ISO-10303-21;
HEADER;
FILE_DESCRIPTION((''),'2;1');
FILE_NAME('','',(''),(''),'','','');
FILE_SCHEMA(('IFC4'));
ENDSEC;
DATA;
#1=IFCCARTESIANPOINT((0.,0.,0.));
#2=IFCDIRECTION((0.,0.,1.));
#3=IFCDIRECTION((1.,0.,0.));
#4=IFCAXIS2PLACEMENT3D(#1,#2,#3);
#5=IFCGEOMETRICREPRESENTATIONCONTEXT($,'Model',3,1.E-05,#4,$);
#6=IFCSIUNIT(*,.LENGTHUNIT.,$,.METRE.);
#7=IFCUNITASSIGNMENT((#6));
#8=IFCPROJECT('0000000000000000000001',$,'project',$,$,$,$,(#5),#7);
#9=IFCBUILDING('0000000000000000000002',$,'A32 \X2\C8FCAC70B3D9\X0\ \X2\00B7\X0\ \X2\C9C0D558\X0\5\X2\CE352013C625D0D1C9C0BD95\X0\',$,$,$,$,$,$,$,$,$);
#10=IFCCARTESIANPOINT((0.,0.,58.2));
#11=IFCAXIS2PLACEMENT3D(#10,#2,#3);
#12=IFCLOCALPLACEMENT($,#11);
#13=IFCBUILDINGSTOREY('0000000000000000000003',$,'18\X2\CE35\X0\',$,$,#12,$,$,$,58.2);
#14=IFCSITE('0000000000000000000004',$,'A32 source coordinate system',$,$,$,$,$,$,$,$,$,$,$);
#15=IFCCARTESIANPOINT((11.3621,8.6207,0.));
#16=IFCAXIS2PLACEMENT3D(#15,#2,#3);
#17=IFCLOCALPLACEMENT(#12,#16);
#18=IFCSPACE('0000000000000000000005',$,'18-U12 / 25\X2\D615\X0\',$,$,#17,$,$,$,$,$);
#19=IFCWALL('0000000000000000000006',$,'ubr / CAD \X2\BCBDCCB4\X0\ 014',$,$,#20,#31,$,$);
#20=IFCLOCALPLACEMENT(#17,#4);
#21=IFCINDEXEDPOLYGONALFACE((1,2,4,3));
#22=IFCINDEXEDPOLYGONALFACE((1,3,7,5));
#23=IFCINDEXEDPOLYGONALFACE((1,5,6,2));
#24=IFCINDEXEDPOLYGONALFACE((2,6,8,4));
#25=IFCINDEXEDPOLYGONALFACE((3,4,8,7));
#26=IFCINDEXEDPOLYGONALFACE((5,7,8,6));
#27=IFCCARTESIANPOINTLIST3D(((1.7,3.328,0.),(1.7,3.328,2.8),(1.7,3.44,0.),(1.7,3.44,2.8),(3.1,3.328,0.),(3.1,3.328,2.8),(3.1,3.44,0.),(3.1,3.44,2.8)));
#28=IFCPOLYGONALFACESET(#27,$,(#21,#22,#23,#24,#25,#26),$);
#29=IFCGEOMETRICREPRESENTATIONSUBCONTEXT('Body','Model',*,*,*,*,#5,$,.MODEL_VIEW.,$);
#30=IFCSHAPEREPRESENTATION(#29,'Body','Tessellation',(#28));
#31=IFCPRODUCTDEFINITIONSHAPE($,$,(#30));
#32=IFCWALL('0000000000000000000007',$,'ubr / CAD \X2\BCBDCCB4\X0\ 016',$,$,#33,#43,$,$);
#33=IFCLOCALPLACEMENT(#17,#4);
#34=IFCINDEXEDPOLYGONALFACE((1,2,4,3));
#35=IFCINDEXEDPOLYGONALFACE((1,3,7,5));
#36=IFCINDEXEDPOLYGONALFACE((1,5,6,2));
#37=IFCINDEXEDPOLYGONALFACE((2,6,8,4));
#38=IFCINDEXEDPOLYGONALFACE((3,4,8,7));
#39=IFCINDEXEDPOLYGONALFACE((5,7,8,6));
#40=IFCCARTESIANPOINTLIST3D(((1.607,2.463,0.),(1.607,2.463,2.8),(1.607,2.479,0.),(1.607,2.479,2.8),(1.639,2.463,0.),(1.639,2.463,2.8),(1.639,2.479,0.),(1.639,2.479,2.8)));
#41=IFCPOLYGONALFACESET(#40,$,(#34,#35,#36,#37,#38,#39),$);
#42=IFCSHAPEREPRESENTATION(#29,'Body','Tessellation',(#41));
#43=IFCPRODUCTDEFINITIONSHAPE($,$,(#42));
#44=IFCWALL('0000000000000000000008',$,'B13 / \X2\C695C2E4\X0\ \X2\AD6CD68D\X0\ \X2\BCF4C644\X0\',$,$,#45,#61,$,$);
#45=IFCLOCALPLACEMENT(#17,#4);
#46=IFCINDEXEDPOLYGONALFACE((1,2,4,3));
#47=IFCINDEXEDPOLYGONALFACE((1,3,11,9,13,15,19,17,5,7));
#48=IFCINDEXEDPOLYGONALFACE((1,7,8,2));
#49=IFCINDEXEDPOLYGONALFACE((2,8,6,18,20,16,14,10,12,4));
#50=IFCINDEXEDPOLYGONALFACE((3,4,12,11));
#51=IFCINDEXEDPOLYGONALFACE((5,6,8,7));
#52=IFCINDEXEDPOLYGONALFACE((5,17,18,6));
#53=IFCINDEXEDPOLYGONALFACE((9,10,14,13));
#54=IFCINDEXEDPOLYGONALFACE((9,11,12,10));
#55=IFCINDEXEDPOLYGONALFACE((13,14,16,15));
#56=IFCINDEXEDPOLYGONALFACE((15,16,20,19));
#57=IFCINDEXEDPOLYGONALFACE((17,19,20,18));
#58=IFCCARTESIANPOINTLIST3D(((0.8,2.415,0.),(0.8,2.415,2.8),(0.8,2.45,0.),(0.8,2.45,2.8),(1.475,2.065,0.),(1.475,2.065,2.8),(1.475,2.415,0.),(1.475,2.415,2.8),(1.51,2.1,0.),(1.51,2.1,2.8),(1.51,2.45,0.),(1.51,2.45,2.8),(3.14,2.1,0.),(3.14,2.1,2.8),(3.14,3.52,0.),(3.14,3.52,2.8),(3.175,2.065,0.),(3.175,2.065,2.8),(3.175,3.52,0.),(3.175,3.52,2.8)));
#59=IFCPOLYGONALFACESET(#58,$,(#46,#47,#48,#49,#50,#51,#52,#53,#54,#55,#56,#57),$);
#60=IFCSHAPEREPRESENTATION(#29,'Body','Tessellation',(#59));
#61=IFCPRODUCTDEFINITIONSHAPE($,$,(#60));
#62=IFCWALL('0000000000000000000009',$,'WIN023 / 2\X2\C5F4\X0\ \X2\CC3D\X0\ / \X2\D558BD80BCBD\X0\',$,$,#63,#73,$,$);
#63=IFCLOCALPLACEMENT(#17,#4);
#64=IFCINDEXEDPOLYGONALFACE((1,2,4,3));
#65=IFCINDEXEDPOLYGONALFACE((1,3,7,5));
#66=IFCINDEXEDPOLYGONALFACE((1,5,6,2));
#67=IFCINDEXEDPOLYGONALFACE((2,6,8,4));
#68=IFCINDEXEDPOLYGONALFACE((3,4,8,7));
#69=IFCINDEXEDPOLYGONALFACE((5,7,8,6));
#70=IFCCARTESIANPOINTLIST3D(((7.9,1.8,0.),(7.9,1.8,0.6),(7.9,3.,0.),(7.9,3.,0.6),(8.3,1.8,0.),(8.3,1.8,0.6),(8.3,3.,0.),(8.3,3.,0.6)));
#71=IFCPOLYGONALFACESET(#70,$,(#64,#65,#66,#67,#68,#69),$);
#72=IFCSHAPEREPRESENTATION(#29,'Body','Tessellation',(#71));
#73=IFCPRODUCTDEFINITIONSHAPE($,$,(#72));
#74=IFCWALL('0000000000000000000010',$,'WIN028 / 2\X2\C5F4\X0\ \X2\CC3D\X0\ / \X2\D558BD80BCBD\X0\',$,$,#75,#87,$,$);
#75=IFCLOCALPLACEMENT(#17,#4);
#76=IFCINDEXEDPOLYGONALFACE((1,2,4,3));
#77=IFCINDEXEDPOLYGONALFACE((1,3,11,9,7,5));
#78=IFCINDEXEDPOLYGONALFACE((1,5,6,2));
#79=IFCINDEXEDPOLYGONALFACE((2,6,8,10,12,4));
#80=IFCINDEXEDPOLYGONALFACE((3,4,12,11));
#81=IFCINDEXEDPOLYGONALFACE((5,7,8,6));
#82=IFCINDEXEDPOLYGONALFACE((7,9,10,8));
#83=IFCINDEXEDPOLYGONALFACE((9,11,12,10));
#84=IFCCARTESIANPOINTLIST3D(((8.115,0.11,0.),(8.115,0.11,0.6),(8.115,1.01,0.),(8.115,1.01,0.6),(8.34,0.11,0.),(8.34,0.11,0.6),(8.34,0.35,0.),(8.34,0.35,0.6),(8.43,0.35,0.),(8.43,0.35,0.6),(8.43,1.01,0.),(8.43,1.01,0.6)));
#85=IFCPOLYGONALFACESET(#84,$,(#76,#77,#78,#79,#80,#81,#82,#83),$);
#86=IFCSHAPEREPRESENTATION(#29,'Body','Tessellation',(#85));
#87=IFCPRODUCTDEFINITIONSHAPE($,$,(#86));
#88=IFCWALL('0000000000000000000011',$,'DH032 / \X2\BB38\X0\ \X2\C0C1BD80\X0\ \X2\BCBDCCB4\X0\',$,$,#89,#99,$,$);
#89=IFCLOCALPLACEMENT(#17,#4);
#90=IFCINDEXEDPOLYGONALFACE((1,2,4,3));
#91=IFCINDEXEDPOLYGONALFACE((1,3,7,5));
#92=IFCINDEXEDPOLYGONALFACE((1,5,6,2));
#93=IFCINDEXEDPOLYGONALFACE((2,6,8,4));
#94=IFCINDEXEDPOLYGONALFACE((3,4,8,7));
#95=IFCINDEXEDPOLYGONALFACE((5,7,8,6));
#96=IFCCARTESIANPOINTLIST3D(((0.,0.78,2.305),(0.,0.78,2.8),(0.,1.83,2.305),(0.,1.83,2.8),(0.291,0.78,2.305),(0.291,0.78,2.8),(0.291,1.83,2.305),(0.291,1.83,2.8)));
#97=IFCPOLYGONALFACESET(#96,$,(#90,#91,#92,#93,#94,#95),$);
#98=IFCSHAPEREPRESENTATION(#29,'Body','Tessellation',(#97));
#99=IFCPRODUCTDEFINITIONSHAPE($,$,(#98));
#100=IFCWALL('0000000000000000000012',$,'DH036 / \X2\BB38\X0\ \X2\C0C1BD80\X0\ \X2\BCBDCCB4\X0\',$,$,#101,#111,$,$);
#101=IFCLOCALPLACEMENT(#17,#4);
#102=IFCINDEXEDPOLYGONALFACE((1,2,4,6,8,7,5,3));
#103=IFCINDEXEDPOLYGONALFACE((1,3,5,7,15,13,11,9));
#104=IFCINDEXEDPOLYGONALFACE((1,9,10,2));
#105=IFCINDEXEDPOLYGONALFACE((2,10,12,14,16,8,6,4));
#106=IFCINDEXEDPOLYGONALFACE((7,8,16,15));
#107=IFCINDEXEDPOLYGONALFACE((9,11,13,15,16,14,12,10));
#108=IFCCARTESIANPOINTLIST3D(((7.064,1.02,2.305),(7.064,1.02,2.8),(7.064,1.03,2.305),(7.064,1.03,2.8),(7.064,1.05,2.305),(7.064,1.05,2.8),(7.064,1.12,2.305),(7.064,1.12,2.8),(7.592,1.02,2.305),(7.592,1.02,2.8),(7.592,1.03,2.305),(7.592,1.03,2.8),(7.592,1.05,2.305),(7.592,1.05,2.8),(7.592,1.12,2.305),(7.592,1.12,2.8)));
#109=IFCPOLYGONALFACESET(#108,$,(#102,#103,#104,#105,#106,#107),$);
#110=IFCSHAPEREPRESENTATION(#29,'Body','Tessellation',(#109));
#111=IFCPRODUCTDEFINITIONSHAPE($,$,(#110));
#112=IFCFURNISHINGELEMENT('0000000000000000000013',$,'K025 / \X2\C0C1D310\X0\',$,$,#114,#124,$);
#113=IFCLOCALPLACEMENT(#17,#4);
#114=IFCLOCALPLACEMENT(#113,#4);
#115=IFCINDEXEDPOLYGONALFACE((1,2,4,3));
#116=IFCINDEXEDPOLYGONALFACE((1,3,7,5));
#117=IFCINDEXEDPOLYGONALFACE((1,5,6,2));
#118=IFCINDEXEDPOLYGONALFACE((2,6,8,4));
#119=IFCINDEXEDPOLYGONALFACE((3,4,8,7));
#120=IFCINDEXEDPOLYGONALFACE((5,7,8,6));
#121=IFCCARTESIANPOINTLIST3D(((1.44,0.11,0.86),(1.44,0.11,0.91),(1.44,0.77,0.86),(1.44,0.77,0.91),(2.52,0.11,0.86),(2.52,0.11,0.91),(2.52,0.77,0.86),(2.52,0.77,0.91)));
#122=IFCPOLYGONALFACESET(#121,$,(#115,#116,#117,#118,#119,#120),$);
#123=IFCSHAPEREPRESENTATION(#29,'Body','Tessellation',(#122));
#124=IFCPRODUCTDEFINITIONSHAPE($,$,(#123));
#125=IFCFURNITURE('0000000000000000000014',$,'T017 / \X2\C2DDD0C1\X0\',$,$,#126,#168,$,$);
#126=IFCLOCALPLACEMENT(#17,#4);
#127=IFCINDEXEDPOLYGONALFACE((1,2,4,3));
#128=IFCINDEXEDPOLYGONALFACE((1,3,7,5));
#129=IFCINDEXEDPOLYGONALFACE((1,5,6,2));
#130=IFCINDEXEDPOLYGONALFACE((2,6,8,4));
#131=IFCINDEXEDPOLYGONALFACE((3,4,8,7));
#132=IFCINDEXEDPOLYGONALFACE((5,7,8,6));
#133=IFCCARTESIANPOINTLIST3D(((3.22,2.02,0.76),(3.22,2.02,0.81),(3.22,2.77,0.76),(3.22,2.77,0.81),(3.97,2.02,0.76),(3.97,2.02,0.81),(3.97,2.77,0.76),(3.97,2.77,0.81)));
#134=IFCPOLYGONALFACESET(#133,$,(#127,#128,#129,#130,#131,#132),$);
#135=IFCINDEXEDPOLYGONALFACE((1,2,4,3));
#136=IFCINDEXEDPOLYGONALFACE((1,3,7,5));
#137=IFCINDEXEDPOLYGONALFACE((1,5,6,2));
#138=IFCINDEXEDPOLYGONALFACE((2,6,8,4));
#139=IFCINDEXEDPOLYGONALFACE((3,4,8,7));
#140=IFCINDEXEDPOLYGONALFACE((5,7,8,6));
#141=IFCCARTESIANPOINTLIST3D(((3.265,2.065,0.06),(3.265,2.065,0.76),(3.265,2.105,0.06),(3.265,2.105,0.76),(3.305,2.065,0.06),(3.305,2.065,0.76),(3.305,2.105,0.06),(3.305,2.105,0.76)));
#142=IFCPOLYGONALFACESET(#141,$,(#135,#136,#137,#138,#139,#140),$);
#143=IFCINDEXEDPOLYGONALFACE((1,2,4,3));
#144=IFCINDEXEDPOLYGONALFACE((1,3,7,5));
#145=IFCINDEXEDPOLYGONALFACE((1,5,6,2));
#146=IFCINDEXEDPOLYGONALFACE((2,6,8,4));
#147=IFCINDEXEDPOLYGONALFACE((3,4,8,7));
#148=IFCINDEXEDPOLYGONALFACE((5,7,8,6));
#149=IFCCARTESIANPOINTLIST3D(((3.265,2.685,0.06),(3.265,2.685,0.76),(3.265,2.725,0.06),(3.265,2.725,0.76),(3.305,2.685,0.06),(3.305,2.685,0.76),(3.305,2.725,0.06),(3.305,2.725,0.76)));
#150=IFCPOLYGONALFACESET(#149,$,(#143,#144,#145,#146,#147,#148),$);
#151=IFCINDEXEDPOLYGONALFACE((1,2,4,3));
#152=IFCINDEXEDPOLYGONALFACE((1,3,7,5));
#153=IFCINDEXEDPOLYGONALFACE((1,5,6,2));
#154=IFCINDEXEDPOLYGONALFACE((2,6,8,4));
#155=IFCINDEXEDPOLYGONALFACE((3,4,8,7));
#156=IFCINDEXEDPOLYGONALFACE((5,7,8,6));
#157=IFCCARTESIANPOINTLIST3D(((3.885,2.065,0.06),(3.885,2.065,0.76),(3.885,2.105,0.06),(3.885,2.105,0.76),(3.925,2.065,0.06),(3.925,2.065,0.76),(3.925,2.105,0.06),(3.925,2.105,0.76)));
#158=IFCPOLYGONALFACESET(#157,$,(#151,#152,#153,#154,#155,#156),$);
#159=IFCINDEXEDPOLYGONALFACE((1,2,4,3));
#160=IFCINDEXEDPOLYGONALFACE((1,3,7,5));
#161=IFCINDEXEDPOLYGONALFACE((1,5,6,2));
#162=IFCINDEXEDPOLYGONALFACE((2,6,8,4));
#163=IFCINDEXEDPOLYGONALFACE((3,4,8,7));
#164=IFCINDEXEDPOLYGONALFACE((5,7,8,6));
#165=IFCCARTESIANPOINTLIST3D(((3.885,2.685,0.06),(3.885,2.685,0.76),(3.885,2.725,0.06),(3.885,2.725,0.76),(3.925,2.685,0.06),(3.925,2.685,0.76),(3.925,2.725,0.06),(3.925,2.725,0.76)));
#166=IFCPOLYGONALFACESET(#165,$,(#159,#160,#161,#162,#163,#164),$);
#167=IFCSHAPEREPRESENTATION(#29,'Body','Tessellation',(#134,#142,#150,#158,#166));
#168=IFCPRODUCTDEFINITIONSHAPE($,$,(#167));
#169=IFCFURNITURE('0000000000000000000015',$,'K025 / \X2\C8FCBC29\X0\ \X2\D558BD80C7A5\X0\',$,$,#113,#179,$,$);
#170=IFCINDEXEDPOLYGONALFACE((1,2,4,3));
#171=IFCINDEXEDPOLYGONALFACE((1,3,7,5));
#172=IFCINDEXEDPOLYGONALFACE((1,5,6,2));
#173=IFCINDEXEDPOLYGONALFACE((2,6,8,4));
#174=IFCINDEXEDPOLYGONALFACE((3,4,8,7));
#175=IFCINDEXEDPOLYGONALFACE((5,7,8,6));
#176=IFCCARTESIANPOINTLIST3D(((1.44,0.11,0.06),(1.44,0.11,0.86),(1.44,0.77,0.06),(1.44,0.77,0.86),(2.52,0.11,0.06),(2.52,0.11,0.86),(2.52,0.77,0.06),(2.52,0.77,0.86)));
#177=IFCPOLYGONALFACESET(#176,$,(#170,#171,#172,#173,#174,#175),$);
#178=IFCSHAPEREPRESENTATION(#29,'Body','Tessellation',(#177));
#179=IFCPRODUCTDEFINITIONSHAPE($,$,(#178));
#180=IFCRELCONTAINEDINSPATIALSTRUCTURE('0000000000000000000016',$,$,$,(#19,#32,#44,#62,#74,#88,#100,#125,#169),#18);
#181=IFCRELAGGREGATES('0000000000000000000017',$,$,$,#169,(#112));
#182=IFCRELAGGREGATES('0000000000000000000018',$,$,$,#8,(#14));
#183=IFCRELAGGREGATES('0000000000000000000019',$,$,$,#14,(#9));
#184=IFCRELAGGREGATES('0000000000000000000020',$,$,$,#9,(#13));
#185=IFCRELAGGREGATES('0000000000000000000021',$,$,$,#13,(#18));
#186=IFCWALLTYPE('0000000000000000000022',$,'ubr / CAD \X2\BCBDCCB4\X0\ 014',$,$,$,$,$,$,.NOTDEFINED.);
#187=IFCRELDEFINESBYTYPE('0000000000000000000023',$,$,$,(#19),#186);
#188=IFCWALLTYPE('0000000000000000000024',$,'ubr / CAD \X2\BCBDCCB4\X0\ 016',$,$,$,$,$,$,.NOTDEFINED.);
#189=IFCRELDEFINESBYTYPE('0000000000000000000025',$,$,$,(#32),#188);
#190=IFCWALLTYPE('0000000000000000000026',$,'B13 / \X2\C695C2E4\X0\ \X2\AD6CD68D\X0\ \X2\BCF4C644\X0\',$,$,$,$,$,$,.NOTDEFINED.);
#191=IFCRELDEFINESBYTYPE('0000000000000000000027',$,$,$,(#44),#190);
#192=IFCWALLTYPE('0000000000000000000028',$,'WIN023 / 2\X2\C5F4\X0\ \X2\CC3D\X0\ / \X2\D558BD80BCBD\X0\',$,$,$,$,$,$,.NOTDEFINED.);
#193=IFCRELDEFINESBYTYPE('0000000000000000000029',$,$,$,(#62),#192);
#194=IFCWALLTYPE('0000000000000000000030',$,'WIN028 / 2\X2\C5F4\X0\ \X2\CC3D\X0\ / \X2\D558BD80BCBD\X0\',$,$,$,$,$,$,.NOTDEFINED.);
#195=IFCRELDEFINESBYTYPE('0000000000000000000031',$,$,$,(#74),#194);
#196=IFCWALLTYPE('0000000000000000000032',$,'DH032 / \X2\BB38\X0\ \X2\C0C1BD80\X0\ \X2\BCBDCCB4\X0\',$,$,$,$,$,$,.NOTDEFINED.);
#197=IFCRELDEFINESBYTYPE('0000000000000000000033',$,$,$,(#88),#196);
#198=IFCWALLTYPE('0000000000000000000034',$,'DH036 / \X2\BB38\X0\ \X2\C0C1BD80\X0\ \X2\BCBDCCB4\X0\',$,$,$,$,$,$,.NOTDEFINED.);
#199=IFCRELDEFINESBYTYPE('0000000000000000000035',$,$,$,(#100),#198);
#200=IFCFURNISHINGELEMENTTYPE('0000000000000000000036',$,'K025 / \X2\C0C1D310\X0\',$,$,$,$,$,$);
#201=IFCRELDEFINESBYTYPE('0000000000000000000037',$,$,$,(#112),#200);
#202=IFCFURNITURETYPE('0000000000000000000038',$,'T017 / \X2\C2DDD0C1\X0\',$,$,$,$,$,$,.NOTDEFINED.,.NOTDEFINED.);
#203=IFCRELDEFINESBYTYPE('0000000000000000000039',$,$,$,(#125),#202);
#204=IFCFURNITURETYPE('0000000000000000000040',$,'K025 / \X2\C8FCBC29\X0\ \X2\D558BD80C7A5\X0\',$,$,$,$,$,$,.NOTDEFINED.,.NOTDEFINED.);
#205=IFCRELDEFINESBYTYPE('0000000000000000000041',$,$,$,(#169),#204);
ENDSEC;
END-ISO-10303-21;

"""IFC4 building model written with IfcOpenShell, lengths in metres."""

from ifc_helpers import new_model, si_unit, frame, origin, origin_with_axes, place, context, subcontext, project, spatial, polyline, outline, extrude, source, transform, mapped, type_object, type_shapes, element, aggregate, save


model = new_model("IFC4")

# Units and contexts
model_context = context("Model", 3, precision=1e-05, world=origin_with_axes())
body_context = subcontext(model_context, "Body", "Model", "MODEL_VIEW")
ifc_project = project(units=[si_unit("LENGTHUNIT", "METRE")], contexts=[model_context])

# Site, building, storey, space
site = spatial("IfcSite", under=ifc_project, Name="A32 source coordinate system")
building = spatial("IfcBuilding", under=site, Name="A32 주거동 · 지하5층–옥탑지붕")
storey_placement = place(None, frame((0.0, 0.0, 58.2), z_axis=(0.0, 0.0, 1.0), x_axis=(1.0, 0.0, 0.0)))
storey = spatial("IfcBuildingStorey", under=building, at=storey_placement, Name="18층", Elevation=58.2)
space_1_placement = place(storey_placement, frame((11.3621, 8.6207, 0.0), z_axis=(0.0, 0.0, 1.0), x_axis=(1.0, 0.0, 0.0)))
space_1 = spatial("IfcSpace", under=storey, at=space_1_placement, Name="18-U12 / 25형")

# Walls
wall_type_1 = type_object("IfcWallType", Name="ubr / CAD 벽체 014", PredefinedType="NOTDEFINED")
shared_shape_1 = source(origin(), body_context, "Body", "SweptSolid", [
    extrude(outline(polyline([(3.1, 3.44), (3.1, 3.328), (1.7, 3.328), (1.7, 3.44), (3.1, 3.44)])), origin(), (0.0, 0.0, 1.0), 2.8),
])
type_shapes(wall_type_1, [shared_shape_1])
wall_1_placement = place(space_1_placement, origin_with_axes())
element("IfcWall", 1, at=wall_1_placement, inside=space_1, type_object=wall_type_1, Name="ubr / CAD 벽체 014", context=body_context, shape_type="MappedRepresentation", body=[
    mapped(shared_shape_1, transform((0.0, 0.0, 0.0), scale=1.0)),
])
wall_type_2 = type_object("IfcWallType", Name="ubr / CAD 벽체 016", PredefinedType="NOTDEFINED")
shared_shape_2 = source(origin(), body_context, "Body", "SweptSolid", [
    extrude(outline(polyline([(1.639, 2.479), (1.639, 2.463), (1.607, 2.463), (1.607, 2.479), (1.639, 2.479)])), origin(), (0.0, 0.0, 1.0), 2.8),
])
type_shapes(wall_type_2, [shared_shape_2])
wall_2_placement = place(space_1_placement, origin_with_axes())
element("IfcWall", 2, at=wall_2_placement, inside=space_1, type_object=wall_type_2, Name="ubr / CAD 벽체 016", context=body_context, shape_type="MappedRepresentation", body=[
    mapped(shared_shape_2, transform((0.0, 0.0, 0.0), scale=1.0)),
])
wall_type_3 = type_object("IfcWallType", Name="B13 / 욕실 구획 보완", PredefinedType="NOTDEFINED")
shared_shape_3 = source(origin(), body_context, "Body", "SweptSolid", [
    extrude(outline(polyline([(0.8, 2.45), (1.51, 2.45), (1.51, 2.1), (3.14, 2.1), (3.14, 3.52), (3.175, 3.52), (3.175, 2.065), (1.475, 2.065), (1.475, 2.415), (0.8, 2.415), (0.8, 2.45)])), origin(), (0.0, 0.0, 1.0), 2.8),
])
type_shapes(wall_type_3, [shared_shape_3])
wall_3_placement = place(space_1_placement, origin_with_axes())
element("IfcWall", 3, at=wall_3_placement, inside=space_1, type_object=wall_type_3, Name="B13 / 욕실 구획 보완", context=body_context, shape_type="MappedRepresentation", body=[
    mapped(shared_shape_3, transform((0.0, 0.0, 0.0), scale=1.0)),
])
wall_type_4 = type_object("IfcWallType", Name="WIN023 / 2열 창 / 하부벽", PredefinedType="NOTDEFINED")
shared_shape_4 = source(origin(), body_context, "Body", "SweptSolid", [
    extrude(outline(polyline([(7.9, 1.8), (7.9, 3.0), (8.3, 3.0), (8.3, 1.8), (7.9, 1.8)])), origin(), (0.0, 0.0, 1.0), 0.6),
])
type_shapes(wall_type_4, [shared_shape_4])
wall_4_placement = place(space_1_placement, origin_with_axes())
element("IfcWall", 4, at=wall_4_placement, inside=space_1, type_object=wall_type_4, Name="WIN023 / 2열 창 / 하부벽", context=body_context, shape_type="MappedRepresentation", body=[
    mapped(shared_shape_4, transform((0.0, 0.0, 0.0), scale=1.0)),
])
wall_type_5 = type_object("IfcWallType", Name="WIN028 / 2열 창 / 하부벽", PredefinedType="NOTDEFINED")
shared_shape_5 = source(origin(), body_context, "Body", "SweptSolid", [
    extrude(outline(polyline([(8.34, 0.35), (8.34, 0.11), (8.115, 0.11), (8.115, 1.01), (8.43, 1.01), (8.43, 0.35), (8.34, 0.35)])), origin(), (0.0, 0.0, 1.0), 0.6),
])
type_shapes(wall_type_5, [shared_shape_5])
wall_5_placement = place(space_1_placement, origin_with_axes())
element("IfcWall", 5, at=wall_5_placement, inside=space_1, type_object=wall_type_5, Name="WIN028 / 2열 창 / 하부벽", context=body_context, shape_type="MappedRepresentation", body=[
    mapped(shared_shape_5, transform((0.0, 0.0, 0.0), scale=1.0)),
])
wall_type_6 = type_object("IfcWallType", Name="DH032 / 문 상부 벽체", PredefinedType="NOTDEFINED")
shared_shape_6 = source(origin(), body_context, "Body", "SweptSolid", [
    extrude(outline(polyline([(0.0, 1.83), (0.291, 1.83), (0.291, 0.78), (0.0, 0.78), (0.0, 1.83)])), frame((0.0, 0.0, 2.305)), (0.0, 0.0, 1.0), 0.495),
])
type_shapes(wall_type_6, [shared_shape_6])
wall_6_placement = place(space_1_placement, origin_with_axes())
element("IfcWall", 6, at=wall_6_placement, inside=space_1, type_object=wall_type_6, Name="DH032 / 문 상부 벽체", context=body_context, shape_type="MappedRepresentation", body=[
    mapped(shared_shape_6, transform((0.0, 0.0, 0.0), scale=1.0)),
])
wall_type_7 = type_object("IfcWallType", Name="DH036 / 문 상부 벽체", PredefinedType="NOTDEFINED")
shared_shape_7 = source(origin(), body_context, "Body", "SweptSolid", [
    extrude(outline(polyline([(7.064, 1.03), (7.064, 1.05), (7.064, 1.12), (7.592, 1.12), (7.592, 1.05), (7.592, 1.03), (7.592, 1.02), (7.064, 1.02), (7.064, 1.03)])), frame((0.0, 0.0, 2.305)), (0.0, 0.0, 1.0), 0.495),
])
type_shapes(wall_type_7, [shared_shape_7])
wall_7_placement = place(space_1_placement, origin_with_axes())
element("IfcWall", 7, at=wall_7_placement, inside=space_1, type_object=wall_type_7, Name="DH036 / 문 상부 벽체", context=body_context, shape_type="MappedRepresentation", body=[
    mapped(shared_shape_7, transform((0.0, 0.0, 0.0), scale=1.0)),
])

# Furnishing element
furnishing_element_type_1 = type_object("IfcFurnishingElementType", Name="K025 / 상판")
shared_shape_8 = source(origin(), body_context, "Body", "SweptSolid", [
    extrude(outline(polyline([(2.52, 0.77), (2.52, 0.11), (1.44, 0.11), (1.44, 0.77), (2.52, 0.77)])), frame((0.0, 0.0, 0.86)), (0.0, 0.0, 1.0), 0.05),
])
type_shapes(furnishing_element_type_1, [shared_shape_8])
furniture_1_placement = place(space_1_placement, origin_with_axes())
furnishing_1_placement = place(furniture_1_placement, origin_with_axes())
furnishing_1 = element("IfcFurnishingElement", 8, at=furnishing_1_placement, type_object=furnishing_element_type_1, Name="K025 / 상판", context=body_context, shape_type="MappedRepresentation", body=[
    mapped(shared_shape_8, transform((0.0, 0.0, 0.0), scale=1.0)),
])

# Furniture
furniture_type_1 = type_object("IfcFurnitureType", Name="T017 / 식탁", AssemblyPlace="NOTDEFINED", PredefinedType="NOTDEFINED")
shared_shape_9 = source(origin(), body_context, "Body", "SweptSolid", [
    extrude(outline(polyline([(3.97, 2.02), (3.22, 2.02), (3.22, 2.77), (3.97, 2.77), (3.97, 2.02)])), frame((0.0, 0.0, 0.76)), (0.0, 0.0, 1.0), 0.05),
    extrude(outline(polyline([(3.265, 2.065), (3.265, 2.105), (3.305, 2.105), (3.305, 2.065), (3.265, 2.065)])), frame((0.0, 0.0, 0.06)), (0.0, 0.0, 1.0), 0.7),
    extrude(outline(polyline([(3.265, 2.685), (3.265, 2.725), (3.305, 2.725), (3.305, 2.685), (3.265, 2.685)])), frame((0.0, 0.0, 0.06)), (0.0, 0.0, 1.0), 0.7),
    extrude(outline(polyline([(3.885, 2.065), (3.885, 2.105), (3.925, 2.105), (3.925, 2.065), (3.885, 2.065)])), frame((0.0, 0.0, 0.06)), (0.0, 0.0, 1.0), 0.7),
    extrude(outline(polyline([(3.885, 2.685), (3.885, 2.725), (3.925, 2.725), (3.925, 2.685), (3.885, 2.685)])), frame((0.0, 0.0, 0.06)), (0.0, 0.0, 1.0), 0.7),
])
type_shapes(furniture_type_1, [shared_shape_9])
furniture_2_placement = place(space_1_placement, origin_with_axes())
element("IfcFurniture", 9, at=furniture_2_placement, inside=space_1, type_object=furniture_type_1, Name="T017 / 식탁", context=body_context, shape_type="MappedRepresentation", body=[
    mapped(shared_shape_9, transform((0.0, 0.0, 0.0), scale=1.0)),
])
furniture_type_2 = type_object("IfcFurnitureType", Name="K025 / 주방 하부장", AssemblyPlace="NOTDEFINED", PredefinedType="NOTDEFINED")
shared_shape_10 = source(origin(), body_context, "Body", "SweptSolid", [
    extrude(outline(polyline([(1.44, 0.77), (2.52, 0.77), (2.52, 0.11), (1.44, 0.11), (1.44, 0.77)])), frame((0.0, 0.0, 0.06)), (0.0, 0.0, 1.0), 0.8),
])
type_shapes(furniture_type_2, [shared_shape_10])
furniture_1 = element("IfcFurniture", 10, at=furniture_1_placement, inside=space_1, type_object=furniture_type_2, Name="K025 / 주방 하부장", context=body_context, shape_type="MappedRepresentation", body=[
    mapped(shared_shape_10, transform((0.0, 0.0, 0.0), scale=1.0)),
])
aggregate(furniture_1, [furnishing_1])

save(model, "model.ifc")
